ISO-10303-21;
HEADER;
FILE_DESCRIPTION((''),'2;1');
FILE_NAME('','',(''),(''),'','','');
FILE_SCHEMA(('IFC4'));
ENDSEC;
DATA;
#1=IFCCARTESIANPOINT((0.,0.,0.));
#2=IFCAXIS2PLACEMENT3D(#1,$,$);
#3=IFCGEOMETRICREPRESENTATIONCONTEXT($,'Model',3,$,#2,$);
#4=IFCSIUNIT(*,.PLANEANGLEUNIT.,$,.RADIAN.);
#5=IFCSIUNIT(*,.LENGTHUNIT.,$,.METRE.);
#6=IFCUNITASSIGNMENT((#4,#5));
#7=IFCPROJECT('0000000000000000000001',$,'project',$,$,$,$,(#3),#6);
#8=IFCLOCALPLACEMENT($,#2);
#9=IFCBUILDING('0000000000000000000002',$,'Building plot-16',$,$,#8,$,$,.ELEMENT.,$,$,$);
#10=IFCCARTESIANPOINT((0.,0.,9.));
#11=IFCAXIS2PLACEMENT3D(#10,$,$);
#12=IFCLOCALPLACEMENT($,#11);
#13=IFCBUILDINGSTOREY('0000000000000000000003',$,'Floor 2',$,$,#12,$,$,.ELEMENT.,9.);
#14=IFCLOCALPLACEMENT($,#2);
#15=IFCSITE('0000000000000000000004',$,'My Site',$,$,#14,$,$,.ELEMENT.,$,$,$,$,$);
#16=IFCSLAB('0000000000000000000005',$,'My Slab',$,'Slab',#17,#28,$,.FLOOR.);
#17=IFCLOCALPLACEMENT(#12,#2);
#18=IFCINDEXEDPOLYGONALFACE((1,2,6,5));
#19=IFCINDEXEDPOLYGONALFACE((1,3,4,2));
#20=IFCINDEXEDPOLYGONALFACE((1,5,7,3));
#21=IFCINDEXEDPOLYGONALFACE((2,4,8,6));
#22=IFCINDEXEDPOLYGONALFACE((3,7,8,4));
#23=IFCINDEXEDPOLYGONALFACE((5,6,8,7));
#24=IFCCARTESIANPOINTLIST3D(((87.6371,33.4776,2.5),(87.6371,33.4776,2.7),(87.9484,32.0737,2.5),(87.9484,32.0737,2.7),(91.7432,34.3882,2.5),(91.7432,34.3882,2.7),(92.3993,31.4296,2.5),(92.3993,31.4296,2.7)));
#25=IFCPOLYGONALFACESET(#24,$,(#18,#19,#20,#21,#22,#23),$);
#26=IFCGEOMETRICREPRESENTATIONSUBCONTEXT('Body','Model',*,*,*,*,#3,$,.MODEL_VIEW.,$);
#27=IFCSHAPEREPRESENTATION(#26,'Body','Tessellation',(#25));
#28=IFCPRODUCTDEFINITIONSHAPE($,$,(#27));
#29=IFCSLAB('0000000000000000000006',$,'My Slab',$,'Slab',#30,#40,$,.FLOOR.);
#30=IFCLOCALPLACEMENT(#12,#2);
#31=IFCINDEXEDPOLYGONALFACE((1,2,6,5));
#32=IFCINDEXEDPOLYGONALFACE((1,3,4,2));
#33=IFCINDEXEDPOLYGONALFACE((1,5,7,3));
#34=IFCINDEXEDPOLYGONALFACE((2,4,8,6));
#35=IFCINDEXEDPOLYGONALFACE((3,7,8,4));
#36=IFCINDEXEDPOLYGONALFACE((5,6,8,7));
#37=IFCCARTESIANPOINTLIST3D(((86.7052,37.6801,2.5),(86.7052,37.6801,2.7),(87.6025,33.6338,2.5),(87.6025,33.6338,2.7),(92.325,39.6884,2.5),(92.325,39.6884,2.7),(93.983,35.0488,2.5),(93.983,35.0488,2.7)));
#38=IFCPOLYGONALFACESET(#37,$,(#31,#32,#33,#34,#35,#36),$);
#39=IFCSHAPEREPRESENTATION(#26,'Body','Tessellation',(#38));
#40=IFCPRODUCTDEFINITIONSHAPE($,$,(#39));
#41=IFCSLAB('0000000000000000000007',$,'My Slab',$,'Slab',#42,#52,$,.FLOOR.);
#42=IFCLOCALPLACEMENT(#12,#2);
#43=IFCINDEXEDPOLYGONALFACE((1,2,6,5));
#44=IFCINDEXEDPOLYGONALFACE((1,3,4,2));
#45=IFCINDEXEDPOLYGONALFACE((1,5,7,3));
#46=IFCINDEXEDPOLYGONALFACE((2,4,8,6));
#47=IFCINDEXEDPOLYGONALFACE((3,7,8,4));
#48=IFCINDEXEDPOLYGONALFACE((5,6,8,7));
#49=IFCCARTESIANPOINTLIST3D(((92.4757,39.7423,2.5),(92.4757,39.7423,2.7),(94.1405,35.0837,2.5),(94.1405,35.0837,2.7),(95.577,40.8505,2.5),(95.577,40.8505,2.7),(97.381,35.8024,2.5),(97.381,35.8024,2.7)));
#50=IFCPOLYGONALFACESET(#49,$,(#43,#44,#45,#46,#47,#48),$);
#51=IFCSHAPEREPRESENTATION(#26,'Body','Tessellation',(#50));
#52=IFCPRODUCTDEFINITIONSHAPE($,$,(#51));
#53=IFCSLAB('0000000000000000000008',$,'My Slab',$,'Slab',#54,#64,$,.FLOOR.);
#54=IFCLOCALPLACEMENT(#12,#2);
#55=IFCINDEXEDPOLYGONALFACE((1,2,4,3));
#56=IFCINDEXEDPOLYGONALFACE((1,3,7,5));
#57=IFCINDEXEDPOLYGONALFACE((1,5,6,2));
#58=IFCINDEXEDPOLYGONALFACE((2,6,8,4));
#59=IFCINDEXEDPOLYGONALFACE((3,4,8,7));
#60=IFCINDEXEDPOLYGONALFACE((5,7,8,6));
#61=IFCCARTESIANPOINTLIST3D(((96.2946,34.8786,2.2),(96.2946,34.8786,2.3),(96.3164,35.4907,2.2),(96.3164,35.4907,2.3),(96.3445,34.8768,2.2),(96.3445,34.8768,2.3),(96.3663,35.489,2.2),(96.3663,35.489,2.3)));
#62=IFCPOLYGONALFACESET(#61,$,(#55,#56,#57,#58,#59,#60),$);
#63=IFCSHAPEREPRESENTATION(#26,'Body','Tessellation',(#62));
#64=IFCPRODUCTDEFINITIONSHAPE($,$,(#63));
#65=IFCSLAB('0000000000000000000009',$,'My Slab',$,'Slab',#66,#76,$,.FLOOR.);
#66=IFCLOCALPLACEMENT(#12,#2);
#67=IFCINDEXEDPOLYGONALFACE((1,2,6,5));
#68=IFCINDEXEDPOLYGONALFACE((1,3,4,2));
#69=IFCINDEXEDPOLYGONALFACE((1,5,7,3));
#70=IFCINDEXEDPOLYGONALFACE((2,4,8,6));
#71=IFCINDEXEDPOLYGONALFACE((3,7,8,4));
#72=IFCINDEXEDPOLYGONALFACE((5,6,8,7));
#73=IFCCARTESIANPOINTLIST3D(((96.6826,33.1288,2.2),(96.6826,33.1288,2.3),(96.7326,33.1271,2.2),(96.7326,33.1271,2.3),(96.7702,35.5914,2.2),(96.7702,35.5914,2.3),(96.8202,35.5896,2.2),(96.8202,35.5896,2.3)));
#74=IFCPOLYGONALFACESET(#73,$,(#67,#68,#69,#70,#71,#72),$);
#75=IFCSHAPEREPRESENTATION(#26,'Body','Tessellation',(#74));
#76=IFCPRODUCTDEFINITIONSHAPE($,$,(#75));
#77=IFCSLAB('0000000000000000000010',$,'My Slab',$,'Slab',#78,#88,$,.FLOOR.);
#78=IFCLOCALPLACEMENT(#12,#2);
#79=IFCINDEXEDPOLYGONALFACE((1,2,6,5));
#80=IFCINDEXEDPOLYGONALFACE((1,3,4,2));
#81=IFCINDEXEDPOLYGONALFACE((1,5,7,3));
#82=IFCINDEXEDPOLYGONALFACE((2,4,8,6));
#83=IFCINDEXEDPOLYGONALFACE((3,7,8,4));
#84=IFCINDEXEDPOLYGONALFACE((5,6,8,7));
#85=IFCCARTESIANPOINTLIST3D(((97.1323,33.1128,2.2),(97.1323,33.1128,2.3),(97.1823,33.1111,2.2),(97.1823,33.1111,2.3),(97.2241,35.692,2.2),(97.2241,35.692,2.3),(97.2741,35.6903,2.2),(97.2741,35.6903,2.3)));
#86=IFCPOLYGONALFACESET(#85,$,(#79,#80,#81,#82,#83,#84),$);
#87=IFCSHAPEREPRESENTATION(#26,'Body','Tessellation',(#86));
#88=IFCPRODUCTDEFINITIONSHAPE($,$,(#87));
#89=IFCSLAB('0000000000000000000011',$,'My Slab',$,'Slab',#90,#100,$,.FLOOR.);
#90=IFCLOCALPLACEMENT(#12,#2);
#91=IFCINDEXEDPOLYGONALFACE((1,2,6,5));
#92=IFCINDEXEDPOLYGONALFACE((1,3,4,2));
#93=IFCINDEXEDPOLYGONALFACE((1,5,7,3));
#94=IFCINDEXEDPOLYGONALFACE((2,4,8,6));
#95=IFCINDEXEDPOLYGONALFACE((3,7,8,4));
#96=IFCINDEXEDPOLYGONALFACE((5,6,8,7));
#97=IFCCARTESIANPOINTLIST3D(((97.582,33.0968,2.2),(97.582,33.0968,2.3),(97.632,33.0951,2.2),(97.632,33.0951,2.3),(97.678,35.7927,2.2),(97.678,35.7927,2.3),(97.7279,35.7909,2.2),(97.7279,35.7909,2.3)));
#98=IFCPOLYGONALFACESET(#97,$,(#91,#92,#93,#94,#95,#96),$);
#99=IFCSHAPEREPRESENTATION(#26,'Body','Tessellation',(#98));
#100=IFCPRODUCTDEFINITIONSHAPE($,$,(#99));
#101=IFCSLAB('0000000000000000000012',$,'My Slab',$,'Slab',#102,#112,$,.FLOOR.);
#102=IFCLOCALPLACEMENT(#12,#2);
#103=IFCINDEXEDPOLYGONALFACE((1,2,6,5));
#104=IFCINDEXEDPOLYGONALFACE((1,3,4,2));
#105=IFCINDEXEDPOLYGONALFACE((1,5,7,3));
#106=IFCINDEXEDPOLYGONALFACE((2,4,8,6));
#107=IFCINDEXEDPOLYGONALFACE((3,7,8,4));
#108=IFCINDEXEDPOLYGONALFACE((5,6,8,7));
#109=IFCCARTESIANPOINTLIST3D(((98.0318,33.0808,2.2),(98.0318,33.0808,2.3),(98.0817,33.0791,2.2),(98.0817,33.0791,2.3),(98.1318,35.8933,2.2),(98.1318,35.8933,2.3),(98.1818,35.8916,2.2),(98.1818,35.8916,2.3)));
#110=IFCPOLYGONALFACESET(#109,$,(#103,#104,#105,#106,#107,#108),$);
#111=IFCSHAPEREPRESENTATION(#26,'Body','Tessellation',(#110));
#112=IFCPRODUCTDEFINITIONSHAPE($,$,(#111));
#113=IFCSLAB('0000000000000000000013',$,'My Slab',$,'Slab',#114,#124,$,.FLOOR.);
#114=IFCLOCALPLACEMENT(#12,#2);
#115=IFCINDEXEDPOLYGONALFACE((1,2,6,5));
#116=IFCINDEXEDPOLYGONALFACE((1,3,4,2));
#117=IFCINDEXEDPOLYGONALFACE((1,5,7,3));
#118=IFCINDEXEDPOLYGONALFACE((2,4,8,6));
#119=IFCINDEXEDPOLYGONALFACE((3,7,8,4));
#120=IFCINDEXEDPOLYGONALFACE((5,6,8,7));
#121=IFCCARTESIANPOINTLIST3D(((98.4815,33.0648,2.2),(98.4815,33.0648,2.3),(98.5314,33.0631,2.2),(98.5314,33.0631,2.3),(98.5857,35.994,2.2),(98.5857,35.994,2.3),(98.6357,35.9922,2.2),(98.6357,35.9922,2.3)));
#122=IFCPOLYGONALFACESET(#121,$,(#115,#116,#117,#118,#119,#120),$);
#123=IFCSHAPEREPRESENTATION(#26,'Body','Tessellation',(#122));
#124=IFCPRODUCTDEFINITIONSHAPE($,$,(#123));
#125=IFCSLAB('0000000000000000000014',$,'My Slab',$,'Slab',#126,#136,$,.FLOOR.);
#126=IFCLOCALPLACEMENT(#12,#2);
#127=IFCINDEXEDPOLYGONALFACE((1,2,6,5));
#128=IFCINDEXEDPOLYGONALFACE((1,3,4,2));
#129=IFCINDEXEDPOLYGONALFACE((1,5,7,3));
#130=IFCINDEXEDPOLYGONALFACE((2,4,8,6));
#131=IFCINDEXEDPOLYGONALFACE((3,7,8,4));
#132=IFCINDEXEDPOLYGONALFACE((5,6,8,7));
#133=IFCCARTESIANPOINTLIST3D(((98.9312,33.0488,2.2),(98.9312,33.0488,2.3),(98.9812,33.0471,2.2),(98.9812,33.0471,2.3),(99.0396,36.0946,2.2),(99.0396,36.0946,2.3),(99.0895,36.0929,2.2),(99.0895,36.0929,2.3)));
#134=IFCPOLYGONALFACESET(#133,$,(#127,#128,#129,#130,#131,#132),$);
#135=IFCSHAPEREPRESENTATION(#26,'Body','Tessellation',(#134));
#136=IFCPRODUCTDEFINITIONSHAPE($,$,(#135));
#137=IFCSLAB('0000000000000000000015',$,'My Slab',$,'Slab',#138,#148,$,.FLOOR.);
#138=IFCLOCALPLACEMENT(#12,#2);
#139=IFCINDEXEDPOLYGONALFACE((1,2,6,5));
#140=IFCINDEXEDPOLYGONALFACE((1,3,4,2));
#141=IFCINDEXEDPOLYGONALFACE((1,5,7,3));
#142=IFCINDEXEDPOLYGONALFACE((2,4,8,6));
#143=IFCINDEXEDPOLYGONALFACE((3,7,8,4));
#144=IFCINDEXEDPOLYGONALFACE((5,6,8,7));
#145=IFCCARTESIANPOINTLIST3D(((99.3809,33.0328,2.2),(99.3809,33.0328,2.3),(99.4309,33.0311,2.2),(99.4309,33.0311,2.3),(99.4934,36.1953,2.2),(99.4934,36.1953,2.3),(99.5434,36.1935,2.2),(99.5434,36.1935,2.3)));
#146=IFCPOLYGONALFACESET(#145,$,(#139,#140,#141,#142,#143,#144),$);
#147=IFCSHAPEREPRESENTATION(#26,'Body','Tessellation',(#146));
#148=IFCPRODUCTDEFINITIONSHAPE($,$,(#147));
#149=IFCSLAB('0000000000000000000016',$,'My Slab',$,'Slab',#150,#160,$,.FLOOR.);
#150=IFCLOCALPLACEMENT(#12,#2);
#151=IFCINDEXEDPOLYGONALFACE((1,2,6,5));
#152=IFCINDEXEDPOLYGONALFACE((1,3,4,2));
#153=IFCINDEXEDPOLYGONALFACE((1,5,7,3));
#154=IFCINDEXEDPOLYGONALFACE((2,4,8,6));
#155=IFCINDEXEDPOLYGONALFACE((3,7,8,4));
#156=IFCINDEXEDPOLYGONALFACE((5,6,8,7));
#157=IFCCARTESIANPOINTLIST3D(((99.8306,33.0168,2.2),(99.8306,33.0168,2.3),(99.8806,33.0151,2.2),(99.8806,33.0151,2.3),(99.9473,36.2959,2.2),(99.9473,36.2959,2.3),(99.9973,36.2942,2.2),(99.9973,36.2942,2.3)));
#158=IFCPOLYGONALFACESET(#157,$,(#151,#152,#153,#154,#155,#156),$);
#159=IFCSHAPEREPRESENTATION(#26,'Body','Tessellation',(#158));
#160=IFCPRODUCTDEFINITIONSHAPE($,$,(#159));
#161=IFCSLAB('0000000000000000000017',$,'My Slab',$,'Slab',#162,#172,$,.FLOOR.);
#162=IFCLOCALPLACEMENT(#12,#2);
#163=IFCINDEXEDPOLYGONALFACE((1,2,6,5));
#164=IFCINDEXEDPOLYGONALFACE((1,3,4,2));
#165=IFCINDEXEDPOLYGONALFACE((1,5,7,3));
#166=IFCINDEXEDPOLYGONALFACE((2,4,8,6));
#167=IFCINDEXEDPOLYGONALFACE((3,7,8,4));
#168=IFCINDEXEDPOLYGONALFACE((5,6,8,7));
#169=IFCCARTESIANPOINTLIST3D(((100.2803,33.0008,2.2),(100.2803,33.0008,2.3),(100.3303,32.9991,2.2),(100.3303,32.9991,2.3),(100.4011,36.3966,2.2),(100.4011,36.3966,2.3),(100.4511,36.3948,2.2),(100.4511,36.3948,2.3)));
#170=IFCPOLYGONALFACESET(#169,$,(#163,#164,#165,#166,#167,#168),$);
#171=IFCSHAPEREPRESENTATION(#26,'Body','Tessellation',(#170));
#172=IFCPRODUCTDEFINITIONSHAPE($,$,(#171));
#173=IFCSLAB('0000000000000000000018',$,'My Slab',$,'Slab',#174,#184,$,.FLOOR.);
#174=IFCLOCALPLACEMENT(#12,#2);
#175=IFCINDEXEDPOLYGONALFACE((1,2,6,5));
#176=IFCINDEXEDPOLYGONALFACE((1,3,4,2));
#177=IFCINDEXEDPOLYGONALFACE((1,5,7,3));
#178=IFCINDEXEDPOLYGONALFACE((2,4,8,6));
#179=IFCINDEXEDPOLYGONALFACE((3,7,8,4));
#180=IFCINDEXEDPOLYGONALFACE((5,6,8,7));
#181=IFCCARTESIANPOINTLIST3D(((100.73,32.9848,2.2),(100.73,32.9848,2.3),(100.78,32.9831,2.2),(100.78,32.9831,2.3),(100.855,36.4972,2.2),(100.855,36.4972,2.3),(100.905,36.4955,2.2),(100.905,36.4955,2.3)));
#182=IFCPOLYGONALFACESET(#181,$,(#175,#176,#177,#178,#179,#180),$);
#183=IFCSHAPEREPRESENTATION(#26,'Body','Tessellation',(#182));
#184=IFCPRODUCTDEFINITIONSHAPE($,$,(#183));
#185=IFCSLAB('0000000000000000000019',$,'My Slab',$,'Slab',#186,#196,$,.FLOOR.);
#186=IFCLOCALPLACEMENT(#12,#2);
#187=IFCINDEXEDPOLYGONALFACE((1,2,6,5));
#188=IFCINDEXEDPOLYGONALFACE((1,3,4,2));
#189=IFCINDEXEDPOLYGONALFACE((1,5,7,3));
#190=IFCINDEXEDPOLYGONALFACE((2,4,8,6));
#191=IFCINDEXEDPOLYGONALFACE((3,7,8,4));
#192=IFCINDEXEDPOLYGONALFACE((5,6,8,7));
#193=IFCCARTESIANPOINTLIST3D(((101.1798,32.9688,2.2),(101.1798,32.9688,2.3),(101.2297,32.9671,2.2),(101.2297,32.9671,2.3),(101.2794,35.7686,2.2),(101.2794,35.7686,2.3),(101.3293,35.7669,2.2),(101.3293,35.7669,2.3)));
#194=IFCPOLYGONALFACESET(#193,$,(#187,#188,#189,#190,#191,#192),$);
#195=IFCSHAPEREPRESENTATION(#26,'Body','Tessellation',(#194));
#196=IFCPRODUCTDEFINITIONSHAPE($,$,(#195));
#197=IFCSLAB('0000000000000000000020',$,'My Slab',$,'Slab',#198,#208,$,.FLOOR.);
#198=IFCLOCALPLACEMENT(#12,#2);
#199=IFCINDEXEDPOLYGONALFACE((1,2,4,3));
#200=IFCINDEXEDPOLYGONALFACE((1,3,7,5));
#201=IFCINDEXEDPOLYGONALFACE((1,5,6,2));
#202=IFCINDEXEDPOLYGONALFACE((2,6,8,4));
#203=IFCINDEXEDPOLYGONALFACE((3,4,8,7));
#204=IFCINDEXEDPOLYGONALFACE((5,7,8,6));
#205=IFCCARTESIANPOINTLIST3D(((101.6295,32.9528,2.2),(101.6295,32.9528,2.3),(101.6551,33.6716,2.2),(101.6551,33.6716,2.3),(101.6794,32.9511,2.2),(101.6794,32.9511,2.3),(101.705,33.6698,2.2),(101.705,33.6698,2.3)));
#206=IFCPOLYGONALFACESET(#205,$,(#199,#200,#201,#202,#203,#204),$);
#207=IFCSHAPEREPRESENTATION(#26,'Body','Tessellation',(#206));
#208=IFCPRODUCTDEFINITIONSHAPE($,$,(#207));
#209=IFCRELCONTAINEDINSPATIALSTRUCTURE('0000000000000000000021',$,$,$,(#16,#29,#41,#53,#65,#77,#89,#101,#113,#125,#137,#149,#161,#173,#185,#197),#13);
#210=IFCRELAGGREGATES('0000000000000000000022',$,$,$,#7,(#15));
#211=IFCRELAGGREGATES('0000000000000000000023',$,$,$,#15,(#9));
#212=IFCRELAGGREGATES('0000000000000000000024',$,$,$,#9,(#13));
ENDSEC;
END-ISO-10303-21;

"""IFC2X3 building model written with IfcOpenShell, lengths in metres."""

from ifc_helpers import new_model, si_unit, frame, origin, place, context, subcontext, project, spatial, polyline, outline, extrude, element, save


model = new_model("IFC2X3")

# Units and contexts
model_context = context("Model", 3, world=origin())
body_context = subcontext(model_context, "Body", "Model", "MODEL_VIEW")
ifc_project = project(units=[si_unit("PLANEANGLEUNIT", "RADIAN"), si_unit("LENGTHUNIT", "METRE")], contexts=[model_context])

# Site, building, storey
site_placement = place(None, origin())
site = spatial("IfcSite", under=ifc_project, at=site_placement, Name="My Site", CompositionType="ELEMENT")
building_placement = place(None, origin())
building = spatial("IfcBuilding", under=site, at=building_placement, Name="Building plot-16", CompositionType="ELEMENT")
storey_placement = place(None, frame((0.0, 0.0, 9.0)))
storey = spatial("IfcBuildingStorey", under=building, at=storey_placement, Name="Floor 2", CompositionType="ELEMENT", Elevation=9.0)

# Slabs
slab_1_placement = place(storey_placement, frame((0.0, 0.0, 2.5)))
element("IfcSlab", 1, at=slab_1_placement, inside=storey, Name="My Slab", ObjectType="Slab", PredefinedType="FLOOR", context=body_context, shape_type="SweptSolid", body=[
    extrude(outline(polyline([(91.7432, 34.3882), (87.6371, 33.4776), (87.9484, 32.0737), (92.3993, 31.4296), (91.7432, 34.3882)])), origin(), (0.0, 0.0, 1.0), 0.2),
])
slab_2_placement = place(storey_placement, frame((0.0, 0.0, 2.5)))
element("IfcSlab", 2, at=slab_2_placement, inside=storey, Name="My Slab", ObjectType="Slab", PredefinedType="FLOOR", context=body_context, shape_type="SweptSolid", body=[
    extrude(outline(polyline([(87.6025, 33.6338), (93.983, 35.0488), (92.325, 39.6884), (86.7052, 37.6801), (87.6025, 33.6338)])), origin(), (0.0, 0.0, 1.0), 0.2),
])
slab_3_placement = place(storey_placement, frame((0.0, 0.0, 2.5)))
element("IfcSlab", 3, at=slab_3_placement, inside=storey, Name="My Slab", ObjectType="Slab", PredefinedType="FLOOR", context=body_context, shape_type="SweptSolid", body=[
    extrude(outline(polyline([(94.1405, 35.0837), (97.381, 35.8024), (95.577, 40.8505), (92.4757, 39.7423), (94.1405, 35.0837)])), origin(), (0.0, 0.0, 1.0), 0.2),
])
slab_4_placement = place(storey_placement, frame((0.0, 0.0, 2.2)))
element("IfcSlab", 4, at=slab_4_placement, inside=storey, Name="My Slab", ObjectType="Slab", PredefinedType="FLOOR", context=body_context, shape_type="SweptSolid", body=[
    extrude(outline(polyline([(96.2946, 34.8786), (96.3445, 34.8768), (96.3663, 35.489), (96.3164, 35.4907), (96.2946, 34.8786)])), origin(), (0.0, 0.0, 1.0), 0.1),
])
slab_5_placement = place(storey_placement, frame((0.0, 0.0, 2.2)))
element("IfcSlab", 5, at=slab_5_placement, inside=storey, Name="My Slab", ObjectType="Slab", PredefinedType="FLOOR", context=body_context, shape_type="SweptSolid", body=[
    extrude(outline(polyline([(96.6826, 33.1288), (96.7326, 33.1271), (96.8202, 35.5896), (96.7702, 35.5914), (96.6826, 33.1288)])), origin(), (0.0, 0.0, 1.0), 0.1),
])
slab_6_placement = place(storey_placement, frame((0.0, 0.0, 2.2)))
element("IfcSlab", 6, at=slab_6_placement, inside=storey, Name="My Slab", ObjectType="Slab", PredefinedType="FLOOR", context=body_context, shape_type="SweptSolid", body=[
    extrude(outline(polyline([(97.1323, 33.1128), (97.1823, 33.1111), (97.2741, 35.6903), (97.2241, 35.692), (97.1323, 33.1128)])), origin(), (0.0, 0.0, 1.0), 0.1),
])
slab_7_placement = place(storey_placement, frame((0.0, 0.0, 2.2)))
element("IfcSlab", 7, at=slab_7_placement, inside=storey, Name="My Slab", ObjectType="Slab", PredefinedType="FLOOR", context=body_context, shape_type="SweptSolid", body=[
    extrude(outline(polyline([(97.582, 33.0968), (97.632, 33.0951), (97.7279, 35.7909), (97.678, 35.7927), (97.582, 33.0968)])), origin(), (0.0, 0.0, 1.0), 0.1),
])
slab_8_placement = place(storey_placement, frame((0.0, 0.0, 2.2)))
element("IfcSlab", 8, at=slab_8_placement, inside=storey, Name="My Slab", ObjectType="Slab", PredefinedType="FLOOR", context=body_context, shape_type="SweptSolid", body=[
    extrude(outline(polyline([(98.0318, 33.0808), (98.0817, 33.0791), (98.1818, 35.8916), (98.1318, 35.8933), (98.0318, 33.0808)])), origin(), (0.0, 0.0, 1.0), 0.1),
])
slab_9_placement = place(storey_placement, frame((0.0, 0.0, 2.2)))
element("IfcSlab", 9, at=slab_9_placement, inside=storey, Name="My Slab", ObjectType="Slab", PredefinedType="FLOOR", context=body_context, shape_type="SweptSolid", body=[
    extrude(outline(polyline([(98.4815, 33.0648), (98.5314, 33.0631), (98.6357, 35.9922), (98.5857, 35.994), (98.4815, 33.0648)])), origin(), (0.0, 0.0, 1.0), 0.1),
])
slab_10_placement = place(storey_placement, frame((0.0, 0.0, 2.2)))
element("IfcSlab", 10, at=slab_10_placement, inside=storey, Name="My Slab", ObjectType="Slab", PredefinedType="FLOOR", context=body_context, shape_type="SweptSolid", body=[
    extrude(outline(polyline([(98.9312, 33.0488), (98.9812, 33.0471), (99.0895, 36.0929), (99.0396, 36.0946), (98.9312, 33.0488)])), origin(), (0.0, 0.0, 1.0), 0.1),
])
slab_11_placement = place(storey_placement, frame((0.0, 0.0, 2.2)))
element("IfcSlab", 11, at=slab_11_placement, inside=storey, Name="My Slab", ObjectType="Slab", PredefinedType="FLOOR", context=body_context, shape_type="SweptSolid", body=[
    extrude(outline(polyline([(99.3809, 33.0328), (99.4309, 33.0311), (99.5434, 36.1935), (99.4934, 36.1953), (99.3809, 33.0328)])), origin(), (0.0, 0.0, 1.0), 0.1),
])
slab_12_placement = place(storey_placement, frame((0.0, 0.0, 2.2)))
element("IfcSlab", 12, at=slab_12_placement, inside=storey, Name="My Slab", ObjectType="Slab", PredefinedType="FLOOR", context=body_context, shape_type="SweptSolid", body=[
    extrude(outline(polyline([(99.8306, 33.0168), (99.8806, 33.0151), (99.9973, 36.2942), (99.9473, 36.2959), (99.8306, 33.0168)])), origin(), (0.0, 0.0, 1.0), 0.1),
])
slab_13_placement = place(storey_placement, frame((0.0, 0.0, 2.2)))
element("IfcSlab", 13, at=slab_13_placement, inside=storey, Name="My Slab", ObjectType="Slab", PredefinedType="FLOOR", context=body_context, shape_type="SweptSolid", body=[
    extrude(outline(polyline([(100.2803, 33.0008), (100.3303, 32.9991), (100.4511, 36.3948), (100.4011, 36.3966), (100.2803, 33.0008)])), origin(), (0.0, 0.0, 1.0), 0.1),
])
slab_14_placement = place(storey_placement, frame((0.0, 0.0, 2.2)))
element("IfcSlab", 14, at=slab_14_placement, inside=storey, Name="My Slab", ObjectType="Slab", PredefinedType="FLOOR", context=body_context, shape_type="SweptSolid", body=[
    extrude(outline(polyline([(100.73, 32.9848), (100.78, 32.9831), (100.905, 36.4955), (100.855, 36.4972), (100.73, 32.9848)])), origin(), (0.0, 0.0, 1.0), 0.1),
])
slab_15_placement = place(storey_placement, frame((0.0, 0.0, 2.2)))
element("IfcSlab", 15, at=slab_15_placement, inside=storey, Name="My Slab", ObjectType="Slab", PredefinedType="FLOOR", context=body_context, shape_type="SweptSolid", body=[
    extrude(outline(polyline([(101.1798, 32.9688), (101.2297, 32.9671), (101.3293, 35.7669), (101.2794, 35.7686), (101.1798, 32.9688)])), origin(), (0.0, 0.0, 1.0), 0.1),
])
slab_16_placement = place(storey_placement, frame((0.0, 0.0, 2.2)))
element("IfcSlab", 16, at=slab_16_placement, inside=storey, Name="My Slab", ObjectType="Slab", PredefinedType="FLOOR", context=body_context, shape_type="SweptSolid", body=[
    extrude(outline(polyline([(101.6295, 32.9528), (101.6794, 32.9511), (101.705, 33.6698), (101.6551, 33.6716), (101.6295, 32.9528)])), origin(), (0.0, 0.0, 1.0), 0.1),
])

save(model, "model.ifc")
